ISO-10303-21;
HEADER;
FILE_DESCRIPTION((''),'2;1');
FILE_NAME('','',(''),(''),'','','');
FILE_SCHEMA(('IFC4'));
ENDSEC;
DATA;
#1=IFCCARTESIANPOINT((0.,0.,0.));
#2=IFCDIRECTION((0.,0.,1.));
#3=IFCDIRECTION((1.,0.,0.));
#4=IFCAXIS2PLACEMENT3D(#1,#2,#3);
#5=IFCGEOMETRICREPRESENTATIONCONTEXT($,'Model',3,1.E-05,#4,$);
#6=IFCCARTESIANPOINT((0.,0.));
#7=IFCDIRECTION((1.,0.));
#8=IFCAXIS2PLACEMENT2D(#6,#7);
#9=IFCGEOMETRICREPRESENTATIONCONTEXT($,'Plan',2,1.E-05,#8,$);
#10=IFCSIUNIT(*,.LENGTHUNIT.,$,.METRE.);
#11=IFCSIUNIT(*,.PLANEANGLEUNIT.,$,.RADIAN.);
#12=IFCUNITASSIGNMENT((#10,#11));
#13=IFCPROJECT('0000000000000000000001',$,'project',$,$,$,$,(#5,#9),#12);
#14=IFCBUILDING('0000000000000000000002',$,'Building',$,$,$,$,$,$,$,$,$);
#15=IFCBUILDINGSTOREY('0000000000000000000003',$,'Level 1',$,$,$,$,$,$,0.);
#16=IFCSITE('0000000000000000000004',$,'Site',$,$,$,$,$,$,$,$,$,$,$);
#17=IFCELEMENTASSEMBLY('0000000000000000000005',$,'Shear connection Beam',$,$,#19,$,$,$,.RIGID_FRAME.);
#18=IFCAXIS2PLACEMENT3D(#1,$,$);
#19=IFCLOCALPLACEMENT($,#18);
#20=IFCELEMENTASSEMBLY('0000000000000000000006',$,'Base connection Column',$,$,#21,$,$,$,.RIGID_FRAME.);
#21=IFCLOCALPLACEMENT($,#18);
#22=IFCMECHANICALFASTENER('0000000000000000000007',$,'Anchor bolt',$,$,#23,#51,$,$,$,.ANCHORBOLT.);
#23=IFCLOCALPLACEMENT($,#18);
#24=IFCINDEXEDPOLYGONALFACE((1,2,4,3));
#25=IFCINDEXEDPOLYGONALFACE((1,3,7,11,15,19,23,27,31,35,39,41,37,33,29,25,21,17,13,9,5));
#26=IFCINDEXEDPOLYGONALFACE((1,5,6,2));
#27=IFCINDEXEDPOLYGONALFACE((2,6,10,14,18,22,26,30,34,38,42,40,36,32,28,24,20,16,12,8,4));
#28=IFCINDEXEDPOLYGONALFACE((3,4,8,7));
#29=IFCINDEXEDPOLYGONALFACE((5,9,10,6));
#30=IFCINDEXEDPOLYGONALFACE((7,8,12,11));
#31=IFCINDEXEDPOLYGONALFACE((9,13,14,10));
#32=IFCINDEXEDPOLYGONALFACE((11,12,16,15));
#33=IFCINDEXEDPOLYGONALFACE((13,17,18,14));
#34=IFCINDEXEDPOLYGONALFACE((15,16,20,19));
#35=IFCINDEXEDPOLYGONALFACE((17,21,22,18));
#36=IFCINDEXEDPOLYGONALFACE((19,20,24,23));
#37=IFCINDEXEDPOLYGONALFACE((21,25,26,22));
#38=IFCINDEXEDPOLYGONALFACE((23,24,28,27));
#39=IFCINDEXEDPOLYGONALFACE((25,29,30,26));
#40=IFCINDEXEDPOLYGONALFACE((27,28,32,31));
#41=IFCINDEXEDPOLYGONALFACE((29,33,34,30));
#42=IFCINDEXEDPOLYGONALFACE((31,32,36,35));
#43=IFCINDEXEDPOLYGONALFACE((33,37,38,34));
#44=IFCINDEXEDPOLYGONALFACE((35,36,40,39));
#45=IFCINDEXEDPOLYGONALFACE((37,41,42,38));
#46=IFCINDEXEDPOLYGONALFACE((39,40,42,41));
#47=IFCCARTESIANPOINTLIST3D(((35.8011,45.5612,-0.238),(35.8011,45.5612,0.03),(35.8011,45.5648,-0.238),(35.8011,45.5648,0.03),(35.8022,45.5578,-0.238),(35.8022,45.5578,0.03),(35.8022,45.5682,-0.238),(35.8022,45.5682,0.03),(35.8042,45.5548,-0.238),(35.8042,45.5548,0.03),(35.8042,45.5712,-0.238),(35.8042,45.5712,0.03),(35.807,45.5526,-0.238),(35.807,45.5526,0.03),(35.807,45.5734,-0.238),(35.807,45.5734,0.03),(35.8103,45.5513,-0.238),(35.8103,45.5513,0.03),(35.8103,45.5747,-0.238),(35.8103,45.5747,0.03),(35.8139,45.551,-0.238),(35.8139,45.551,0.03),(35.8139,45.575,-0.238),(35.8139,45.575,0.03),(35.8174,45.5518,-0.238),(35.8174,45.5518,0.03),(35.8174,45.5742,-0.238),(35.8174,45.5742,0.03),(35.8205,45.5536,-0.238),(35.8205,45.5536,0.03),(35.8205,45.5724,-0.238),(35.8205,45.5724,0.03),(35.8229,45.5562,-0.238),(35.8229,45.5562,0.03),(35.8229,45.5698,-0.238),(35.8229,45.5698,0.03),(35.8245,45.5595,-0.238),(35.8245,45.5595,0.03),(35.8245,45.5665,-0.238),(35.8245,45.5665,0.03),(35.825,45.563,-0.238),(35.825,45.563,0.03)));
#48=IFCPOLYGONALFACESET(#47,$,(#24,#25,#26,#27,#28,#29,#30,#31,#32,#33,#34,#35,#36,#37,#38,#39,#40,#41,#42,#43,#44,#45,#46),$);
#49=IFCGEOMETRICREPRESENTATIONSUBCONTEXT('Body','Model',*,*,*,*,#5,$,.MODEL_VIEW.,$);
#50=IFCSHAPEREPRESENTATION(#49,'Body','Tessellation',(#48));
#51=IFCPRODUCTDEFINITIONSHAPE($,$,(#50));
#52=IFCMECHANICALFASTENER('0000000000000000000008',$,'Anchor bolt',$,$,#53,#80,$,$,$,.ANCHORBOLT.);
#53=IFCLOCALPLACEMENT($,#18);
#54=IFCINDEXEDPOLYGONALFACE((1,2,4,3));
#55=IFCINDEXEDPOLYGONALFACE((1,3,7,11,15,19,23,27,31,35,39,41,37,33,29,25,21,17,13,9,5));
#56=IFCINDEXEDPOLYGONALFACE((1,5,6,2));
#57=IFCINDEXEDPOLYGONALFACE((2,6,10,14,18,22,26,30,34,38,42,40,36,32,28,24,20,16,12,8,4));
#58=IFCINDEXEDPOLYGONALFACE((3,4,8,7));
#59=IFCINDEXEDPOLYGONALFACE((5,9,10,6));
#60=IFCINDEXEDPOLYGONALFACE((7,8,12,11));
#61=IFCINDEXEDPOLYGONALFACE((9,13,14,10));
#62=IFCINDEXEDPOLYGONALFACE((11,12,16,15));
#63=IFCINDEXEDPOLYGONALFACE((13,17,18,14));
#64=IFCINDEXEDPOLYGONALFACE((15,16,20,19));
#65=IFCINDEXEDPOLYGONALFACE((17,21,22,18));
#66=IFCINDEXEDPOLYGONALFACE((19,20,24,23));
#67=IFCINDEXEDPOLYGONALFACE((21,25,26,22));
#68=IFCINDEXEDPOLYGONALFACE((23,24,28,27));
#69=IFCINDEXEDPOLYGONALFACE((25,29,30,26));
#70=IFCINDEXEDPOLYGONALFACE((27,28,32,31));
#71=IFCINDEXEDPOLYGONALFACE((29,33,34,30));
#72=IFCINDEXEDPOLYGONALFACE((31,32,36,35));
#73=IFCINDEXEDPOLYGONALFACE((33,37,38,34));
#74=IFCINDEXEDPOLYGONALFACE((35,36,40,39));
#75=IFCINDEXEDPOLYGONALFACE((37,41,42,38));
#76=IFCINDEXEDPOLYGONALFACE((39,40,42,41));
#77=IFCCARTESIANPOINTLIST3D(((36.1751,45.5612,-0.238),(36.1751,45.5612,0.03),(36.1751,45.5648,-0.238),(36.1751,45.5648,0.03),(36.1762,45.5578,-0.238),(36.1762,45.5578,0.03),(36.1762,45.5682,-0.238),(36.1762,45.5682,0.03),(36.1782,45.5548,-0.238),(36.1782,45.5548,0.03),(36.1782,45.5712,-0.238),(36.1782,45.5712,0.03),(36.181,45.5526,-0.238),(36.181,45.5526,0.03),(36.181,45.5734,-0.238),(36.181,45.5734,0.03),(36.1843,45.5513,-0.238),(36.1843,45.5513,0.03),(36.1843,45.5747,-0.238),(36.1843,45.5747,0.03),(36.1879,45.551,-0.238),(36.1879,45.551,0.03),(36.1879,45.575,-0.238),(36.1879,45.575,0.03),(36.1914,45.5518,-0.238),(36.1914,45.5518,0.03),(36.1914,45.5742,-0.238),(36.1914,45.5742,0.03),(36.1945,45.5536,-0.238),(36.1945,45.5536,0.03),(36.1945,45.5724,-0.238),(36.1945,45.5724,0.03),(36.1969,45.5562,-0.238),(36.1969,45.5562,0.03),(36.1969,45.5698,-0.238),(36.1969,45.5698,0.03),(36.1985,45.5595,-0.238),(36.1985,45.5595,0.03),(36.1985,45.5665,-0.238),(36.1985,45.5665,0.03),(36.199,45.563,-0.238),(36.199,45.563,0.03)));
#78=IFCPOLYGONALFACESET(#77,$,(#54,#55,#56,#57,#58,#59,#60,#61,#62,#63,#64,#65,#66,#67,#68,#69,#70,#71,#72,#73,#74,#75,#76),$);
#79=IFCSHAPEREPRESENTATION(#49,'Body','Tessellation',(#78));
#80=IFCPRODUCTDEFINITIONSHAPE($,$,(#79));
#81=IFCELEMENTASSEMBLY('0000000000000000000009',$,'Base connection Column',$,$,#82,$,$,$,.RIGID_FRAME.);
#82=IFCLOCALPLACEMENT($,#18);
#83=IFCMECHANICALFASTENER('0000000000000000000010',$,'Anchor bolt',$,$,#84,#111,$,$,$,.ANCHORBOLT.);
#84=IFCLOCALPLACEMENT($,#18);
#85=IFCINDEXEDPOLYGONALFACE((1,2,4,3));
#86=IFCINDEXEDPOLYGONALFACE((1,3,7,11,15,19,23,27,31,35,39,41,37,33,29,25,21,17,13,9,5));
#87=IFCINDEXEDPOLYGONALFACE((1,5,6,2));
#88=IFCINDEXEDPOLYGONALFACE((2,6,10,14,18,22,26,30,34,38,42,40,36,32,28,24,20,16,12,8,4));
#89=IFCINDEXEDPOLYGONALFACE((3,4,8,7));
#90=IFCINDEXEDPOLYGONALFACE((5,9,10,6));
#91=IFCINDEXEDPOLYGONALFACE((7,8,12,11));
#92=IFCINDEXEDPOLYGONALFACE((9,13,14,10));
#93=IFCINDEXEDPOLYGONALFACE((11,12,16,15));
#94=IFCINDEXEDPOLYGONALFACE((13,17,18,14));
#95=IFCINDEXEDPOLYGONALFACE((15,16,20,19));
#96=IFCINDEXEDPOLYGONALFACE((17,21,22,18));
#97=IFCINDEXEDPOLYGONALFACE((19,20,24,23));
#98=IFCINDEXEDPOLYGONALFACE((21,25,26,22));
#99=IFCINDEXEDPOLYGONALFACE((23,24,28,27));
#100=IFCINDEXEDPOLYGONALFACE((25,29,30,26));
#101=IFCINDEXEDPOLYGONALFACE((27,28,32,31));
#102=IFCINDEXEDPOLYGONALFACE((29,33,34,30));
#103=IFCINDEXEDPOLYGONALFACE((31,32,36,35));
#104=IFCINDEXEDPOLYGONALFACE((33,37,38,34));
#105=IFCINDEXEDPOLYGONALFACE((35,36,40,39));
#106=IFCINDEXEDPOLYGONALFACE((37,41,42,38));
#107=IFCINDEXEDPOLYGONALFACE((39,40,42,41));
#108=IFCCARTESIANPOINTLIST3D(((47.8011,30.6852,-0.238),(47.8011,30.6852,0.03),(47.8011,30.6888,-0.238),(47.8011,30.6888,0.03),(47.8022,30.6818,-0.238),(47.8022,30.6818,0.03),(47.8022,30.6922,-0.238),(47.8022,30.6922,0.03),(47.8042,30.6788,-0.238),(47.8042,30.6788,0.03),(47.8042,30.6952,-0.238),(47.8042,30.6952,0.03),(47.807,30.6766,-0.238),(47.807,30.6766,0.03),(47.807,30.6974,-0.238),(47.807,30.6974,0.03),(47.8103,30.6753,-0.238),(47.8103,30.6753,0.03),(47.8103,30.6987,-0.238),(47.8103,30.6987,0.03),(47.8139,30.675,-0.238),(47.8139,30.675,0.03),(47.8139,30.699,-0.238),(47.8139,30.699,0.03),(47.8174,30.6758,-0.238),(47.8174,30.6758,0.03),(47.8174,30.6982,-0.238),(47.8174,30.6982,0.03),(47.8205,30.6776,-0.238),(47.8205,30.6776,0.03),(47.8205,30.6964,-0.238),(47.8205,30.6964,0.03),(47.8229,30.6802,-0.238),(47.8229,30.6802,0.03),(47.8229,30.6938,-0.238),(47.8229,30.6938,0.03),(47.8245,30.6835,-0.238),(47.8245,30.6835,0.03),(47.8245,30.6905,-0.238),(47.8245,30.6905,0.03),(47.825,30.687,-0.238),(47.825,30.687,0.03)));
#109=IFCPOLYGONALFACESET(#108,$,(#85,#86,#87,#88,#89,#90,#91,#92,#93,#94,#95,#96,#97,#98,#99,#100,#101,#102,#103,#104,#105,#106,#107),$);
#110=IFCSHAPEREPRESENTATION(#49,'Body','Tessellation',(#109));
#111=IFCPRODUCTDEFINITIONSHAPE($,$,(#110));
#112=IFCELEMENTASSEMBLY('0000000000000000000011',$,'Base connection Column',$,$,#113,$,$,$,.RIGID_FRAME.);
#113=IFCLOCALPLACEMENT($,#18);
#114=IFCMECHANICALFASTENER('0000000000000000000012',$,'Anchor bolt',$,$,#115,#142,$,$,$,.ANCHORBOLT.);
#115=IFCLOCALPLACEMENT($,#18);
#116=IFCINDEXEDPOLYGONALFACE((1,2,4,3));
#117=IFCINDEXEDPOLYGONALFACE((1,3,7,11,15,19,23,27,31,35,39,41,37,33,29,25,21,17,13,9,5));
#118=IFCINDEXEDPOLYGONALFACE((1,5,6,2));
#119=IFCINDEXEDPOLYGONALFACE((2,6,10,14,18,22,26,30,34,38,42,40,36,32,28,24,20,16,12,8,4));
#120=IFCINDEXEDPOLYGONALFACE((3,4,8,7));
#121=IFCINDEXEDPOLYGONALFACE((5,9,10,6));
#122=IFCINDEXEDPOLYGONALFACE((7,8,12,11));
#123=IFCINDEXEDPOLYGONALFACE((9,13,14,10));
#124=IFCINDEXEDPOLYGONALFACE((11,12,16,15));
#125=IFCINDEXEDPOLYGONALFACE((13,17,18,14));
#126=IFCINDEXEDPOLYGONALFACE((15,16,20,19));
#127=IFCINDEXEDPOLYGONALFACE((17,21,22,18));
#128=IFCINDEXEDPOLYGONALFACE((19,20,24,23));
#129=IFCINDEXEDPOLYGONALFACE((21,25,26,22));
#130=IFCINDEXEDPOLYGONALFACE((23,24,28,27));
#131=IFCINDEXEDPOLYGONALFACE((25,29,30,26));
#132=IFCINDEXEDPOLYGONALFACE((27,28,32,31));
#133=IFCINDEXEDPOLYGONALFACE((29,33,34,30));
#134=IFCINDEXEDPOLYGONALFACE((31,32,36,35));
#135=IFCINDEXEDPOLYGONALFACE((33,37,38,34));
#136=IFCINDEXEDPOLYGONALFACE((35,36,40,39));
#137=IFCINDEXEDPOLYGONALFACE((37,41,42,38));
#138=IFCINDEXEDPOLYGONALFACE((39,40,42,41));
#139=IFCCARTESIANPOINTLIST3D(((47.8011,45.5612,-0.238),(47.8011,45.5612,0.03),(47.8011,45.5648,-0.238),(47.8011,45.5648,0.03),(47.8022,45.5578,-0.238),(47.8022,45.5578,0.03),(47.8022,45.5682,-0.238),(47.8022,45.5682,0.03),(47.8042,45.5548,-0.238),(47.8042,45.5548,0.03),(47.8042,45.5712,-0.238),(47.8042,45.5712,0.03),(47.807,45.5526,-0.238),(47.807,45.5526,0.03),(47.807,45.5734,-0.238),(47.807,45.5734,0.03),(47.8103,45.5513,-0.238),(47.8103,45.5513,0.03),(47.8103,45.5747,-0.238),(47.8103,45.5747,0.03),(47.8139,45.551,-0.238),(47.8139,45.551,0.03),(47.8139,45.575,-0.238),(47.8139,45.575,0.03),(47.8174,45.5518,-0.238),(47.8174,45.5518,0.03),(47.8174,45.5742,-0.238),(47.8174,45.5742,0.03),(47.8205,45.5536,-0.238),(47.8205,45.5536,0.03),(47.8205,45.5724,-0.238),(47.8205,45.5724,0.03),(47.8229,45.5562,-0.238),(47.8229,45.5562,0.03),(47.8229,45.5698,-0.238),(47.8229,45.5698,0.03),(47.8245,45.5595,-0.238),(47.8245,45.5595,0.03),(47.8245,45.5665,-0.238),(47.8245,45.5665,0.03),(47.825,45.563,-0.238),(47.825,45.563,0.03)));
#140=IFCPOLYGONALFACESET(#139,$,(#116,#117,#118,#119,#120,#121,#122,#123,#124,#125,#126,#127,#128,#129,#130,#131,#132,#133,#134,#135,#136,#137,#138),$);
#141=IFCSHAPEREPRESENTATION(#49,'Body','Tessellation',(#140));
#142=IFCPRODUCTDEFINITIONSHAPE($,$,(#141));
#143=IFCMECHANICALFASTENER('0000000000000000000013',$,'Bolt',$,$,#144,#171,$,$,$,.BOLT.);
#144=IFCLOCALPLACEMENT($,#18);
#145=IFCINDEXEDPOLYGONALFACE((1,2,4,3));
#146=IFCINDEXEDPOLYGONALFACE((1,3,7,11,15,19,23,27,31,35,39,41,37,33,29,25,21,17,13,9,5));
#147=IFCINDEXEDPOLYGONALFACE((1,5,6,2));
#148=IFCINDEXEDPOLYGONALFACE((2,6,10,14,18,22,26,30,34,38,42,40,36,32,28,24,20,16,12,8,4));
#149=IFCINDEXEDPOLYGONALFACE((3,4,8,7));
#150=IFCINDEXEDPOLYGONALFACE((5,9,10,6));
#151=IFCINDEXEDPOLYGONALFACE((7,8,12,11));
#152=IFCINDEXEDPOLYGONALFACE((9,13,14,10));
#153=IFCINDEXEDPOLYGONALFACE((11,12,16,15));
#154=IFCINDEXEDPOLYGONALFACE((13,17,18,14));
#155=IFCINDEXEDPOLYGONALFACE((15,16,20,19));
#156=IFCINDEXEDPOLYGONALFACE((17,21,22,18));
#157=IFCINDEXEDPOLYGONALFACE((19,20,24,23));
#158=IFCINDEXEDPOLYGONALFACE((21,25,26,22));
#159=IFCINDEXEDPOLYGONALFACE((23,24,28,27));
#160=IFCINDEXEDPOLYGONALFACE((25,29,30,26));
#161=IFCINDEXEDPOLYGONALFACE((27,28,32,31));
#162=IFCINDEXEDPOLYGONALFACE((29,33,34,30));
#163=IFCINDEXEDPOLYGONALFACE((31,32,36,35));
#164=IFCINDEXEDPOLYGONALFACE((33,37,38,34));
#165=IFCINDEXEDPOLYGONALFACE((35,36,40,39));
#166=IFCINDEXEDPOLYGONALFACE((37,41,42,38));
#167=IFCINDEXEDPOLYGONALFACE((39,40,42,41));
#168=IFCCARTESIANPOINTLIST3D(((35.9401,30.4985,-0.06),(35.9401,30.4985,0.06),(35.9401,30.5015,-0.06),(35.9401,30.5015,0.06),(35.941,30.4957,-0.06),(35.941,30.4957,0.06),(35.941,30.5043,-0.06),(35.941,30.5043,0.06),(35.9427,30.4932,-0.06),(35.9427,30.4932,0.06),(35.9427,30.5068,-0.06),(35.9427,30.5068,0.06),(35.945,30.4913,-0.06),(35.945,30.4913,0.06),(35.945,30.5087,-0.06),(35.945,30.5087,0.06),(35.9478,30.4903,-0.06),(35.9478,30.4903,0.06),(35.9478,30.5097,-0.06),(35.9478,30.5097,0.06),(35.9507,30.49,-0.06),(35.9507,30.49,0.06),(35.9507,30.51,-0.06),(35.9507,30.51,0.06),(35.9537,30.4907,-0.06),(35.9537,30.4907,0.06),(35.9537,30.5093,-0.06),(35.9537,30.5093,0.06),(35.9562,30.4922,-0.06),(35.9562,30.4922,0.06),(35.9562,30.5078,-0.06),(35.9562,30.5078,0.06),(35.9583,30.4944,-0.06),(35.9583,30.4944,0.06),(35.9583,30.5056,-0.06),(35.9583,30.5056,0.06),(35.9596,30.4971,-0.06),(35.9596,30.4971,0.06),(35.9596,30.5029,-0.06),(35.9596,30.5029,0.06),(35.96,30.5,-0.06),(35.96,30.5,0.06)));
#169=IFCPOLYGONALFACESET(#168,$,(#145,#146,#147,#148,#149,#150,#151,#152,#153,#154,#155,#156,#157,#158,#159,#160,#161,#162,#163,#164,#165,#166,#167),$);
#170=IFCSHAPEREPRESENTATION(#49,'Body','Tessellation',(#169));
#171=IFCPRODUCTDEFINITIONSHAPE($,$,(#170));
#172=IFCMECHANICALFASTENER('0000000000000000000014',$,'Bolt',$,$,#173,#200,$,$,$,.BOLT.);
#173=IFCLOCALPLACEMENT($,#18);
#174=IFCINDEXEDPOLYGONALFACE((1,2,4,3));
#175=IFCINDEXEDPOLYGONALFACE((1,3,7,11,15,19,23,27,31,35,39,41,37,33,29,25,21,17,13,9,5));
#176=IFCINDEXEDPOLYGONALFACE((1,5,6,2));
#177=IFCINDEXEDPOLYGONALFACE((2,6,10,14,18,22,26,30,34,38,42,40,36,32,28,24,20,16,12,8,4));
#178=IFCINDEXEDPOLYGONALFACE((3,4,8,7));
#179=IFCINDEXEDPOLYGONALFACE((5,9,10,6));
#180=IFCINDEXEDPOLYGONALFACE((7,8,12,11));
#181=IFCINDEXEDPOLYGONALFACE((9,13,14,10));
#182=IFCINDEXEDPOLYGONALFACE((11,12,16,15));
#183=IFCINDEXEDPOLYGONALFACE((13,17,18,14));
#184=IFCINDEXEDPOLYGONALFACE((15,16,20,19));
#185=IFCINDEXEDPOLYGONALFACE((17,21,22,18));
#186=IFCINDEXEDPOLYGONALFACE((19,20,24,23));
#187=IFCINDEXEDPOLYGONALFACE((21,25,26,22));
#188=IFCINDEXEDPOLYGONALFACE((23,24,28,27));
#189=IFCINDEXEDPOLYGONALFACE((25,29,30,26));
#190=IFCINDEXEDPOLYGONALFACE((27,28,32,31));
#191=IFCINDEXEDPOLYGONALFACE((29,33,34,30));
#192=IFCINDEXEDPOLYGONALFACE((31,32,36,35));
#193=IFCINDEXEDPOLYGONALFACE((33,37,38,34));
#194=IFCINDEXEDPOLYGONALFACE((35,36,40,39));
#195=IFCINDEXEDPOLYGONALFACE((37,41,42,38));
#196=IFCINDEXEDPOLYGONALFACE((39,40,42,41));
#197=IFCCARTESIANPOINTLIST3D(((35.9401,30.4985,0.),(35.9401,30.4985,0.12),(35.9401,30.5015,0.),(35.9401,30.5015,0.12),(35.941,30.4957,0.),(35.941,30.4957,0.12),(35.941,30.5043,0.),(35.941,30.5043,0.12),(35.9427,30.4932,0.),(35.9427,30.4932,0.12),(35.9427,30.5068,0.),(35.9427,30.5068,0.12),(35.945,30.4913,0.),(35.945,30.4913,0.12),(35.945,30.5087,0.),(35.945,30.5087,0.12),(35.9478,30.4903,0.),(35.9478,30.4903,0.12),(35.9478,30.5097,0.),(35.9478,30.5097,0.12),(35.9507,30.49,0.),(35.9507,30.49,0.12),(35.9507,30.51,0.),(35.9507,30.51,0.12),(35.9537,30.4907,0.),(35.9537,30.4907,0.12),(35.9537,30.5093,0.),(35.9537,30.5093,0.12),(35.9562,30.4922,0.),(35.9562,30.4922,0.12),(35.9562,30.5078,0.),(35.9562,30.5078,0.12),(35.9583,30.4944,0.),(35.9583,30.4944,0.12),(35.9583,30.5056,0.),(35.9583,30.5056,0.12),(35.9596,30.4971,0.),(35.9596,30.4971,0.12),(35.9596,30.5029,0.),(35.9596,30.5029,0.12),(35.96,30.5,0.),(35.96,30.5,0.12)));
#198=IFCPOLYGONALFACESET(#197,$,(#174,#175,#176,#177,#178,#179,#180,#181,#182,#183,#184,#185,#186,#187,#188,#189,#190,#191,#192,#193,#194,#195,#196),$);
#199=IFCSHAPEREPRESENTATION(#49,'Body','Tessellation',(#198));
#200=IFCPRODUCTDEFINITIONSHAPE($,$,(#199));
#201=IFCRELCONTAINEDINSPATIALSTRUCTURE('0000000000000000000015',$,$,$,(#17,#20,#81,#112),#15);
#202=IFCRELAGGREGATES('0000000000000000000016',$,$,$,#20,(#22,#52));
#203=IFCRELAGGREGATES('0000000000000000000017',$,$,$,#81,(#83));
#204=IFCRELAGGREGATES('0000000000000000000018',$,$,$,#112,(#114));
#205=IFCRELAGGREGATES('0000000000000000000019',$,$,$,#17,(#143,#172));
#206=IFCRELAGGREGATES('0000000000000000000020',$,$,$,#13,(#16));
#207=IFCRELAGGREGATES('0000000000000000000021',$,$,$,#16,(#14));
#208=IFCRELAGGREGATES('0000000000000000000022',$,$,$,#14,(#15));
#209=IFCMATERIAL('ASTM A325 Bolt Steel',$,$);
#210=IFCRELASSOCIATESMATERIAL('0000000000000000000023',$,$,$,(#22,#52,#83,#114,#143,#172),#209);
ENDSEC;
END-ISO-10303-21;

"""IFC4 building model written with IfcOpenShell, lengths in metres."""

from ifc_helpers import new_model, si_unit, frame, origin_with_axes, origin_2d, origin_2d_with_axis, place, context, subcontext, project, spatial, circle, extrude, material, element, aggregate, save


model = new_model("IFC4")

# Units and contexts
model_context = context("Model", 3, precision=1e-05, world=origin_with_axes())
plan_context = context("Plan", 2, precision=1e-05, world=origin_2d_with_axis())
body_context = subcontext(model_context, "Body", "Model", "MODEL_VIEW")
ifc_project = project(units=[si_unit("LENGTHUNIT", "METRE"), si_unit("PLANEANGLEUNIT", "RADIAN")], contexts=[model_context, plan_context])

# Site, building, storey
site = spatial("IfcSite", under=ifc_project, Name="Site")
building = spatial("IfcBuilding", under=site, Name="Building")
storey = spatial("IfcBuildingStorey", under=building, Name="Level 1", Elevation=0.0)

# Element assembly
assembly_1 = element("IfcElementAssembly", 1, inside=storey, Name="Shear connection Beam", PredefinedType="RIGID_FRAME")

# Shared definitions
ifc_material_1 = material(Name="ASTM A325 Bolt Steel")

# Element assembly, mechanical fasteners
assembly_2 = element("IfcElementAssembly", 2, inside=storey, Name="Base connection Column", PredefinedType="RIGID_FRAME")
mechanical_fastener_1_placement = place(None, frame((35.813, 45.563, -0.238), z_axis=(0.0, 0.0, 1.0), x_axis=(1.0, 0.0, 0.0)))
mechanical_fastener_1 = element("IfcMechanicalFastener", 3, at=mechanical_fastener_1_placement, material=ifc_material_1, Name="Anchor bolt", PredefinedType="ANCHORBOLT", context=body_context, shape_type="SweptSolid", body=[
    extrude(circle(Radius=0.012, at=origin_2d()), origin_with_axes(), (0.0, 0.0, 1.0), 0.268),
])
mechanical_fastener_2_placement = place(None, frame((36.187, 45.563, -0.238), z_axis=(0.0, 0.0, 1.0), x_axis=(1.0, 0.0, 0.0)))
mechanical_fastener_2 = element("IfcMechanicalFastener", 4, at=mechanical_fastener_2_placement, material=ifc_material_1, Name="Anchor bolt", PredefinedType="ANCHORBOLT", context=body_context, shape_type="SweptSolid", body=[
    extrude(circle(Radius=0.012, at=origin_2d()), origin_with_axes(), (0.0, 0.0, 1.0), 0.268),
])
aggregate(assembly_2, [mechanical_fastener_1, mechanical_fastener_2])

# Element assemblies, mechanical fasteners
assembly_3 = element("IfcElementAssembly", 5, inside=storey, Name="Base connection Column", PredefinedType="RIGID_FRAME")
mechanical_fastener_3_placement = place(None, frame((47.813, 30.687, -0.238), z_axis=(0.0, 0.0, 1.0), x_axis=(1.0, 0.0, 0.0)))
mechanical_fastener_3 = element("IfcMechanicalFastener", 6, at=mechanical_fastener_3_placement, material=ifc_material_1, Name="Anchor bolt", PredefinedType="ANCHORBOLT", context=body_context, shape_type="SweptSolid", body=[
    extrude(circle(Radius=0.012, at=origin_2d()), origin_with_axes(), (0.0, 0.0, 1.0), 0.268),
])
aggregate(assembly_3, [mechanical_fastener_3])
assembly_4 = element("IfcElementAssembly", 7, inside=storey, Name="Base connection Column", PredefinedType="RIGID_FRAME")
mechanical_fastener_4_placement = place(None, frame((47.813, 45.563, -0.238), z_axis=(0.0, 0.0, 1.0), x_axis=(1.0, 0.0, 0.0)))
mechanical_fastener_4 = element("IfcMechanicalFastener", 8, at=mechanical_fastener_4_placement, material=ifc_material_1, Name="Anchor bolt", PredefinedType="ANCHORBOLT", context=body_context, shape_type="SweptSolid", body=[
    extrude(circle(Radius=0.012, at=origin_2d()), origin_with_axes(), (0.0, 0.0, 1.0), 0.268),
])
aggregate(assembly_4, [mechanical_fastener_4])

# Mechanical fasteners
mechanical_fastener_5_placement = place(None, frame((35.95, 30.5, -0.06), z_axis=(0.0, 0.0, 1.0), x_axis=(1.0, 0.0, 0.0)))
mechanical_fastener_5 = element("IfcMechanicalFastener", 9, at=mechanical_fastener_5_placement, material=ifc_material_1, Name="Bolt", PredefinedType="BOLT", context=body_context, shape_type="SweptSolid", body=[
    extrude(circle(Radius=0.01, at=origin_2d()), origin_with_axes(), (0.0, 0.0, 1.0), 0.12),
])
mechanical_fastener_6_placement = place(None, frame((35.95, 30.5, 0.0), z_axis=(0.0, 0.0, 1.0), x_axis=(1.0, 0.0, 0.0)))
mechanical_fastener_6 = element("IfcMechanicalFastener", 10, at=mechanical_fastener_6_placement, material=ifc_material_1, Name="Bolt", PredefinedType="BOLT", context=body_context, shape_type="SweptSolid", body=[
    extrude(circle(Radius=0.01, at=origin_2d()), origin_with_axes(), (0.0, 0.0, 1.0), 0.12),
])
aggregate(assembly_1, [mechanical_fastener_5, mechanical_fastener_6])

save(model, "model.ifc")
